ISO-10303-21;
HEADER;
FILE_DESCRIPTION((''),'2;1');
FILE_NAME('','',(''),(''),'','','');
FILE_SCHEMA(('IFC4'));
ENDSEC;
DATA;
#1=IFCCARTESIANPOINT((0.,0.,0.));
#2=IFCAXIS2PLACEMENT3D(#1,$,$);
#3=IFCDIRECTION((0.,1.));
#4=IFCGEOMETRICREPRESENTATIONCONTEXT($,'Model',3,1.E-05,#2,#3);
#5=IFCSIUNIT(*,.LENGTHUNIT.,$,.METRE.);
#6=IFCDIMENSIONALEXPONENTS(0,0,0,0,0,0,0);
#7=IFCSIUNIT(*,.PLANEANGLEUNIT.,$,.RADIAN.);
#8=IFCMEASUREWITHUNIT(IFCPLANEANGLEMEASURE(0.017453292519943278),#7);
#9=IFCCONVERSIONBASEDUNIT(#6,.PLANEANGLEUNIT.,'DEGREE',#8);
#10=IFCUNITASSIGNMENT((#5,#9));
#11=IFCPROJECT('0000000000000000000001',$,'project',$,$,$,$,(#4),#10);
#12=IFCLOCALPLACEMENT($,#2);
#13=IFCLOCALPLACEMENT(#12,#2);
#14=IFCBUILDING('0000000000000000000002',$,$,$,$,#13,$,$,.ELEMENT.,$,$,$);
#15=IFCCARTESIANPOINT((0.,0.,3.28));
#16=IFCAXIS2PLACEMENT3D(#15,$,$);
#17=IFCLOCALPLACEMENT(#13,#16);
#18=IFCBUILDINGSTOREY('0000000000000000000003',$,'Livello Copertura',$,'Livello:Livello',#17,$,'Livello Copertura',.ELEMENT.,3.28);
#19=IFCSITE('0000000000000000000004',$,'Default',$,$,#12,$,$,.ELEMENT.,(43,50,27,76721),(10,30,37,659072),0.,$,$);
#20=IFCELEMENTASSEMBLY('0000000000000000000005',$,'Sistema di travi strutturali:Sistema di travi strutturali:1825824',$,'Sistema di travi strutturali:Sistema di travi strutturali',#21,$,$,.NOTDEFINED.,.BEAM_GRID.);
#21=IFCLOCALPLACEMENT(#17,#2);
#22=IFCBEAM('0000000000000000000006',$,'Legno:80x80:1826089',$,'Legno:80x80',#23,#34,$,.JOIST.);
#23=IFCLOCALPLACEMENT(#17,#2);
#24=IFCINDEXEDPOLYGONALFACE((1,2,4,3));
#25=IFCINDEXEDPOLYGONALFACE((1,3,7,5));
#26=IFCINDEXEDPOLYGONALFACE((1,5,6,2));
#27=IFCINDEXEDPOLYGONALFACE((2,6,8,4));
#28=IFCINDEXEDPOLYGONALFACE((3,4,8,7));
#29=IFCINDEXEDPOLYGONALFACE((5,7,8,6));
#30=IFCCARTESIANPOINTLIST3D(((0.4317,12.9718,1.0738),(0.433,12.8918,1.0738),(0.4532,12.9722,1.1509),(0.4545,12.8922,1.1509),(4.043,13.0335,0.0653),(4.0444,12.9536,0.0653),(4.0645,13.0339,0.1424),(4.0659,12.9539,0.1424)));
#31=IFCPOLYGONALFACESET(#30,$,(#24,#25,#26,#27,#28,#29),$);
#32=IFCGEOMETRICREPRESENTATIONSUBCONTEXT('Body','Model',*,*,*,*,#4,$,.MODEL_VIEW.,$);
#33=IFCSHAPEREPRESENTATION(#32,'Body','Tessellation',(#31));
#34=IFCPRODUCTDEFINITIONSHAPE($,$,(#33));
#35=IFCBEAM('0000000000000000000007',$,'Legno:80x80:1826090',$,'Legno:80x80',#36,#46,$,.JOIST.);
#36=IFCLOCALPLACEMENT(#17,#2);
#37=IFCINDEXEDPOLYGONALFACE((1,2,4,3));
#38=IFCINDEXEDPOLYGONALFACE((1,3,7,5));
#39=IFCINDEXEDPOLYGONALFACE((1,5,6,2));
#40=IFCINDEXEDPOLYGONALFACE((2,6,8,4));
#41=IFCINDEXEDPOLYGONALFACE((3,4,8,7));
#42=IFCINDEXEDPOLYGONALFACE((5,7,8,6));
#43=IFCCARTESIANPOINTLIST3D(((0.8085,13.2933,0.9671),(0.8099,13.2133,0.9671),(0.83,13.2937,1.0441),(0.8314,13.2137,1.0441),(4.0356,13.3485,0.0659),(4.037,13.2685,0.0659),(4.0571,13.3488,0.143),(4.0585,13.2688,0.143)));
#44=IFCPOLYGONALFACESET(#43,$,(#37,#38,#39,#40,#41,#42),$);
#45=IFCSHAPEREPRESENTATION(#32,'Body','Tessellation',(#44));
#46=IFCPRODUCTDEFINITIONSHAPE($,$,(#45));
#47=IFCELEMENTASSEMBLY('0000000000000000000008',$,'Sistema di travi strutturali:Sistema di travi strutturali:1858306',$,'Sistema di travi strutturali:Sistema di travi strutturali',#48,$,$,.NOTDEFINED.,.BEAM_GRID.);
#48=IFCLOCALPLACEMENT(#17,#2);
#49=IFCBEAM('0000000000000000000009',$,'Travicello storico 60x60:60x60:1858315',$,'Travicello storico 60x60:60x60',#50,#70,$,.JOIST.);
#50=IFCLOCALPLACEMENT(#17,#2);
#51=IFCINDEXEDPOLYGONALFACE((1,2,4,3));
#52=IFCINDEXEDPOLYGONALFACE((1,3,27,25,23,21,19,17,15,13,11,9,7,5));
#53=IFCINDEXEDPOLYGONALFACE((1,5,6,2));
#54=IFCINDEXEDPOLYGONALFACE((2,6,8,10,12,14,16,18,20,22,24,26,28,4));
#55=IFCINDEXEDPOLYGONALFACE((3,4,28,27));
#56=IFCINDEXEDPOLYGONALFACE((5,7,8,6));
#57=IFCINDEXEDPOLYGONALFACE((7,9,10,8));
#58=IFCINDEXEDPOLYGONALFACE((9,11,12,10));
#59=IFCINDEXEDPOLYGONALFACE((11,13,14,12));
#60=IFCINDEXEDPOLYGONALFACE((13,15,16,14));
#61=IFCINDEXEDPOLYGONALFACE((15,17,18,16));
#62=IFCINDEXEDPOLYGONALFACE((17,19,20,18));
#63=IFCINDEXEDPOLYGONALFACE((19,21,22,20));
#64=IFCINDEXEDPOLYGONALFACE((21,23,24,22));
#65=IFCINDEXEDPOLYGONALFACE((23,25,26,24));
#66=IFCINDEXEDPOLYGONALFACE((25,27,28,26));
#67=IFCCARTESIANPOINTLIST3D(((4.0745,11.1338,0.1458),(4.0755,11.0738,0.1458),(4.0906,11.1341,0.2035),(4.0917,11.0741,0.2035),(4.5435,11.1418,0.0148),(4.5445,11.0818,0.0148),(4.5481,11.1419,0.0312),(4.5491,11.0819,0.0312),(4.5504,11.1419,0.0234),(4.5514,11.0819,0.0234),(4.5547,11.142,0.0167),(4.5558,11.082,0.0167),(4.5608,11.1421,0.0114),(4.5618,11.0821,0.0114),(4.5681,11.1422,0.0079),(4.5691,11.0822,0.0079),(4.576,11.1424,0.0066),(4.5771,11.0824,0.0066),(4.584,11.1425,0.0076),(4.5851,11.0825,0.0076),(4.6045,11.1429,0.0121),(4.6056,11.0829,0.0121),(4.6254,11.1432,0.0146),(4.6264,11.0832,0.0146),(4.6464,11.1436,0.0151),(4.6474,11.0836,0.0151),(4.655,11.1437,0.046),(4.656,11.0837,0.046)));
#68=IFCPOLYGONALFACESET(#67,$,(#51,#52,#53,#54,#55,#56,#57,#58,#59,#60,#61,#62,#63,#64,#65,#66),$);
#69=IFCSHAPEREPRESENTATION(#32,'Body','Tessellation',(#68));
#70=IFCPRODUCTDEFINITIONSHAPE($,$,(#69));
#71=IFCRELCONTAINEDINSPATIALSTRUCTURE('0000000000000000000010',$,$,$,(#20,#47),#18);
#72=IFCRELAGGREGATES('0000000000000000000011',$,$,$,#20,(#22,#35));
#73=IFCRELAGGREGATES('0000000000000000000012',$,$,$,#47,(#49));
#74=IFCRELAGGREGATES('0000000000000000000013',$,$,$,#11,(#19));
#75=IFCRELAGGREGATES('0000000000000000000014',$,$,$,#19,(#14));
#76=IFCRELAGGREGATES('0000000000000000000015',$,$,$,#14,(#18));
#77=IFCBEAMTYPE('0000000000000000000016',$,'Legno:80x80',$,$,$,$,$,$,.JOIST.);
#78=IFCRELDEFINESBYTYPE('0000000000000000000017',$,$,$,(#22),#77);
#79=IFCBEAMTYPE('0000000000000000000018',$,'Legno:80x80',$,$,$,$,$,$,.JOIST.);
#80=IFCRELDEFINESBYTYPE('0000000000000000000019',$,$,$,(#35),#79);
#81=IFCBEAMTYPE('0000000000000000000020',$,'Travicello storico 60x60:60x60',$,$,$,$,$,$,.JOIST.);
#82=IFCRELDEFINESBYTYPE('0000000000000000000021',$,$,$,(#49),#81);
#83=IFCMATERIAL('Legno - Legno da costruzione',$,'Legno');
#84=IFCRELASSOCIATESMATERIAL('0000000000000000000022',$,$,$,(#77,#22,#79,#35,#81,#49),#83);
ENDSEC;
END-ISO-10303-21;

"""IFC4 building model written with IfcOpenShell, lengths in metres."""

from ifc_helpers import new_model, entity, si_unit, converted_unit, direction, frame, origin, place, context, subcontext, project, spatial, line, arc, indexed_curve, outline, extrude, source, transform, mapped, material, type_object, type_shapes, element, aggregate, save


model = new_model("IFC4")

# Units and contexts
model_context = context("Model", 3, precision=1e-05, world=origin(), true_north=direction((0.0, 1.0)))
body_context = subcontext(model_context, "Body", "Model", "MODEL_VIEW")
ifc_project = project(units=[si_unit("LENGTHUNIT", "METRE"), converted_unit("PLANEANGLEUNIT", "DEGREE", entity("IfcPlaneAngleMeasure", 0.017453292519943278), si_unit("PLANEANGLEUNIT", "RADIAN"), dimensions=[0, 0, 0, 0, 0, 0, 0])], contexts=[model_context])

# Site, building, storey
site_placement = place(None, origin())
site = spatial("IfcSite", under=ifc_project, at=site_placement, Name="Default", CompositionType="ELEMENT", RefLatitude=(43, 50, 27, 76721), RefLongitude=(10, 30, 37, 659072), RefElevation=0.0)
building_placement = place(site_placement, origin())
building = spatial("IfcBuilding", under=site, at=building_placement, CompositionType="ELEMENT")
storey_placement = place(building_placement, frame((0.0, 0.0, 3.28)))
storey = spatial("IfcBuildingStorey", under=building, at=storey_placement, Name="Livello Copertura", ObjectType="Livello:Livello", LongName="Livello Copertura", CompositionType="ELEMENT", Elevation=3.28)

# Shared definitions
ifc_material = material(Name="Legno - Legno da costruzione", Category="Legno")

# Element assemblies, beams
assembly_1_placement = place(storey_placement, origin())
assembly_1 = element("IfcElementAssembly", 1, at=assembly_1_placement, inside=storey, Name="Sistema di travi strutturali:Sistema di travi strutturali:1825824", ObjectType="Sistema di travi strutturali:Sistema di travi strutturali", AssemblyPlace="NOTDEFINED", PredefinedType="BEAM_GRID")
beam_type_1 = type_object("IfcBeamType", Name="Legno:80x80", PredefinedType="JOIST", material=ifc_material)
shared_shape_1 = source(origin(), body_context, "Body", "SweptSolid", [
    extrude(outline(indexed_curve([(-1.875, -0.04), (1.875, -0.04), (1.875, 0.04), (-1.875, 0.04), (-1.875, -0.04)], self_intersect=False)), frame((0.0, 0.0, -0.04), z_axis=(0.0, 0.0, 1.0), x_axis=(-1.0, 0.0, 0.0)), (0.0, 0.0, 1.0), 0.08),
])
type_shapes(beam_type_1, [shared_shape_1])
beam_1_placement = place(assembly_1_placement, frame((2.2488, 12.9629, 0.6081), z_axis=(0.268881, 0.004594, 0.963163), x_axis=(-0.963022, -0.016456, 0.26892)))
beam_1 = element("IfcBeam", 2, at=beam_1_placement, type_object=beam_type_1, material=ifc_material, Name="Legno:80x80:1826089", ObjectType="Legno:80x80", PredefinedType="JOIST", context=body_context, shape_type="MappedRepresentation", body=[
    mapped(shared_shape_1, transform((0.0, 0.0, 0.0), scale=1.0)),
])
beam_type_2 = type_object("IfcBeamType", Name="Legno:80x80", PredefinedType="JOIST", material=ifc_material)
shared_shape_2 = source(origin(), body_context, "Body", "SweptSolid", [
    extrude(outline(indexed_curve([(-1.6755, -0.04), (1.6755, -0.04), (1.6755, 0.04), (-1.6755, 0.04), (-1.6755, -0.04)], self_intersect=False)), frame((0.0, 0.0, -0.04), z_axis=(0.0, 0.0, 1.0), x_axis=(-1.0, 0.0, 0.0)), (0.0, 0.0, 1.0), 0.08),
])
type_shapes(beam_type_2, [shared_shape_2])
beam_2_placement = place(assembly_1_placement, frame((2.4335, 13.2811, 0.555), z_axis=(0.268881, 0.004594, 0.963163), x_axis=(-0.963022, -0.016456, 0.26892)))
beam_2 = element("IfcBeam", 3, at=beam_2_placement, type_object=beam_type_2, material=ifc_material, Name="Legno:80x80:1826090", ObjectType="Legno:80x80", PredefinedType="JOIST", context=body_context, shape_type="MappedRepresentation", body=[
    mapped(shared_shape_2, transform((0.0, 0.0, 0.0), scale=1.0)),
])
aggregate(assembly_1, [beam_1, beam_2])
assembly_2_placement = place(storey_placement, origin())
assembly_2 = element("IfcElementAssembly", 4, at=assembly_2_placement, inside=storey, Name="Sistema di travi strutturali:Sistema di travi strutturali:1858306", ObjectType="Sistema di travi strutturali:Sistema di travi strutturali", AssemblyPlace="NOTDEFINED", PredefinedType="BEAM_GRID")
beam_type_3 = type_object("IfcBeamType", Name="Travicello storico 60x60:60x60", PredefinedType="JOIST", material=ifc_material)
shared_shape_3 = source(origin(), body_context, "Body", "SweptSolid", [
    extrude(outline(indexed_curve([(-0.0359, -0.382), (0.0241, -0.382), (0.0241, 0.105), (0.0071, 0.105), (0.0228, 0.1226), (0.0201, 0.146), (0.0061, 0.1742), (-0.0039, 0.204), (-0.0359, 0.204)], segments=[line(1, 2, 3, 4), arc(4, 5, 6), arc(6, 7, 8), line(8, 9, 1)], self_intersect=False)), frame((0.051, -0.03, -0.0059), z_axis=(0.0, 1.0, 0.0), x_axis=(0.0, 0.0, -1.0)), (0.0, 0.0, 1.0), 0.06),
])
type_shapes(beam_type_3, [shared_shape_3])
beam_3_placement = place(assembly_2_placement, frame((4.5001, 11.1111, 0.0582), z_axis=(0.268881, 0.004594, 0.963163), x_axis=(-0.963022, -0.016456, 0.26892)))
beam_3 = element("IfcBeam", 5, at=beam_3_placement, type_object=beam_type_3, material=ifc_material, Name="Travicello storico 60x60:60x60:1858315", ObjectType="Travicello storico 60x60:60x60", PredefinedType="JOIST", context=body_context, shape_type="MappedRepresentation", body=[
    mapped(shared_shape_3, transform((0.0, 0.0, 0.0), scale=1.0)),
])
aggregate(assembly_2, [beam_3])

save(model, "model.ifc")
